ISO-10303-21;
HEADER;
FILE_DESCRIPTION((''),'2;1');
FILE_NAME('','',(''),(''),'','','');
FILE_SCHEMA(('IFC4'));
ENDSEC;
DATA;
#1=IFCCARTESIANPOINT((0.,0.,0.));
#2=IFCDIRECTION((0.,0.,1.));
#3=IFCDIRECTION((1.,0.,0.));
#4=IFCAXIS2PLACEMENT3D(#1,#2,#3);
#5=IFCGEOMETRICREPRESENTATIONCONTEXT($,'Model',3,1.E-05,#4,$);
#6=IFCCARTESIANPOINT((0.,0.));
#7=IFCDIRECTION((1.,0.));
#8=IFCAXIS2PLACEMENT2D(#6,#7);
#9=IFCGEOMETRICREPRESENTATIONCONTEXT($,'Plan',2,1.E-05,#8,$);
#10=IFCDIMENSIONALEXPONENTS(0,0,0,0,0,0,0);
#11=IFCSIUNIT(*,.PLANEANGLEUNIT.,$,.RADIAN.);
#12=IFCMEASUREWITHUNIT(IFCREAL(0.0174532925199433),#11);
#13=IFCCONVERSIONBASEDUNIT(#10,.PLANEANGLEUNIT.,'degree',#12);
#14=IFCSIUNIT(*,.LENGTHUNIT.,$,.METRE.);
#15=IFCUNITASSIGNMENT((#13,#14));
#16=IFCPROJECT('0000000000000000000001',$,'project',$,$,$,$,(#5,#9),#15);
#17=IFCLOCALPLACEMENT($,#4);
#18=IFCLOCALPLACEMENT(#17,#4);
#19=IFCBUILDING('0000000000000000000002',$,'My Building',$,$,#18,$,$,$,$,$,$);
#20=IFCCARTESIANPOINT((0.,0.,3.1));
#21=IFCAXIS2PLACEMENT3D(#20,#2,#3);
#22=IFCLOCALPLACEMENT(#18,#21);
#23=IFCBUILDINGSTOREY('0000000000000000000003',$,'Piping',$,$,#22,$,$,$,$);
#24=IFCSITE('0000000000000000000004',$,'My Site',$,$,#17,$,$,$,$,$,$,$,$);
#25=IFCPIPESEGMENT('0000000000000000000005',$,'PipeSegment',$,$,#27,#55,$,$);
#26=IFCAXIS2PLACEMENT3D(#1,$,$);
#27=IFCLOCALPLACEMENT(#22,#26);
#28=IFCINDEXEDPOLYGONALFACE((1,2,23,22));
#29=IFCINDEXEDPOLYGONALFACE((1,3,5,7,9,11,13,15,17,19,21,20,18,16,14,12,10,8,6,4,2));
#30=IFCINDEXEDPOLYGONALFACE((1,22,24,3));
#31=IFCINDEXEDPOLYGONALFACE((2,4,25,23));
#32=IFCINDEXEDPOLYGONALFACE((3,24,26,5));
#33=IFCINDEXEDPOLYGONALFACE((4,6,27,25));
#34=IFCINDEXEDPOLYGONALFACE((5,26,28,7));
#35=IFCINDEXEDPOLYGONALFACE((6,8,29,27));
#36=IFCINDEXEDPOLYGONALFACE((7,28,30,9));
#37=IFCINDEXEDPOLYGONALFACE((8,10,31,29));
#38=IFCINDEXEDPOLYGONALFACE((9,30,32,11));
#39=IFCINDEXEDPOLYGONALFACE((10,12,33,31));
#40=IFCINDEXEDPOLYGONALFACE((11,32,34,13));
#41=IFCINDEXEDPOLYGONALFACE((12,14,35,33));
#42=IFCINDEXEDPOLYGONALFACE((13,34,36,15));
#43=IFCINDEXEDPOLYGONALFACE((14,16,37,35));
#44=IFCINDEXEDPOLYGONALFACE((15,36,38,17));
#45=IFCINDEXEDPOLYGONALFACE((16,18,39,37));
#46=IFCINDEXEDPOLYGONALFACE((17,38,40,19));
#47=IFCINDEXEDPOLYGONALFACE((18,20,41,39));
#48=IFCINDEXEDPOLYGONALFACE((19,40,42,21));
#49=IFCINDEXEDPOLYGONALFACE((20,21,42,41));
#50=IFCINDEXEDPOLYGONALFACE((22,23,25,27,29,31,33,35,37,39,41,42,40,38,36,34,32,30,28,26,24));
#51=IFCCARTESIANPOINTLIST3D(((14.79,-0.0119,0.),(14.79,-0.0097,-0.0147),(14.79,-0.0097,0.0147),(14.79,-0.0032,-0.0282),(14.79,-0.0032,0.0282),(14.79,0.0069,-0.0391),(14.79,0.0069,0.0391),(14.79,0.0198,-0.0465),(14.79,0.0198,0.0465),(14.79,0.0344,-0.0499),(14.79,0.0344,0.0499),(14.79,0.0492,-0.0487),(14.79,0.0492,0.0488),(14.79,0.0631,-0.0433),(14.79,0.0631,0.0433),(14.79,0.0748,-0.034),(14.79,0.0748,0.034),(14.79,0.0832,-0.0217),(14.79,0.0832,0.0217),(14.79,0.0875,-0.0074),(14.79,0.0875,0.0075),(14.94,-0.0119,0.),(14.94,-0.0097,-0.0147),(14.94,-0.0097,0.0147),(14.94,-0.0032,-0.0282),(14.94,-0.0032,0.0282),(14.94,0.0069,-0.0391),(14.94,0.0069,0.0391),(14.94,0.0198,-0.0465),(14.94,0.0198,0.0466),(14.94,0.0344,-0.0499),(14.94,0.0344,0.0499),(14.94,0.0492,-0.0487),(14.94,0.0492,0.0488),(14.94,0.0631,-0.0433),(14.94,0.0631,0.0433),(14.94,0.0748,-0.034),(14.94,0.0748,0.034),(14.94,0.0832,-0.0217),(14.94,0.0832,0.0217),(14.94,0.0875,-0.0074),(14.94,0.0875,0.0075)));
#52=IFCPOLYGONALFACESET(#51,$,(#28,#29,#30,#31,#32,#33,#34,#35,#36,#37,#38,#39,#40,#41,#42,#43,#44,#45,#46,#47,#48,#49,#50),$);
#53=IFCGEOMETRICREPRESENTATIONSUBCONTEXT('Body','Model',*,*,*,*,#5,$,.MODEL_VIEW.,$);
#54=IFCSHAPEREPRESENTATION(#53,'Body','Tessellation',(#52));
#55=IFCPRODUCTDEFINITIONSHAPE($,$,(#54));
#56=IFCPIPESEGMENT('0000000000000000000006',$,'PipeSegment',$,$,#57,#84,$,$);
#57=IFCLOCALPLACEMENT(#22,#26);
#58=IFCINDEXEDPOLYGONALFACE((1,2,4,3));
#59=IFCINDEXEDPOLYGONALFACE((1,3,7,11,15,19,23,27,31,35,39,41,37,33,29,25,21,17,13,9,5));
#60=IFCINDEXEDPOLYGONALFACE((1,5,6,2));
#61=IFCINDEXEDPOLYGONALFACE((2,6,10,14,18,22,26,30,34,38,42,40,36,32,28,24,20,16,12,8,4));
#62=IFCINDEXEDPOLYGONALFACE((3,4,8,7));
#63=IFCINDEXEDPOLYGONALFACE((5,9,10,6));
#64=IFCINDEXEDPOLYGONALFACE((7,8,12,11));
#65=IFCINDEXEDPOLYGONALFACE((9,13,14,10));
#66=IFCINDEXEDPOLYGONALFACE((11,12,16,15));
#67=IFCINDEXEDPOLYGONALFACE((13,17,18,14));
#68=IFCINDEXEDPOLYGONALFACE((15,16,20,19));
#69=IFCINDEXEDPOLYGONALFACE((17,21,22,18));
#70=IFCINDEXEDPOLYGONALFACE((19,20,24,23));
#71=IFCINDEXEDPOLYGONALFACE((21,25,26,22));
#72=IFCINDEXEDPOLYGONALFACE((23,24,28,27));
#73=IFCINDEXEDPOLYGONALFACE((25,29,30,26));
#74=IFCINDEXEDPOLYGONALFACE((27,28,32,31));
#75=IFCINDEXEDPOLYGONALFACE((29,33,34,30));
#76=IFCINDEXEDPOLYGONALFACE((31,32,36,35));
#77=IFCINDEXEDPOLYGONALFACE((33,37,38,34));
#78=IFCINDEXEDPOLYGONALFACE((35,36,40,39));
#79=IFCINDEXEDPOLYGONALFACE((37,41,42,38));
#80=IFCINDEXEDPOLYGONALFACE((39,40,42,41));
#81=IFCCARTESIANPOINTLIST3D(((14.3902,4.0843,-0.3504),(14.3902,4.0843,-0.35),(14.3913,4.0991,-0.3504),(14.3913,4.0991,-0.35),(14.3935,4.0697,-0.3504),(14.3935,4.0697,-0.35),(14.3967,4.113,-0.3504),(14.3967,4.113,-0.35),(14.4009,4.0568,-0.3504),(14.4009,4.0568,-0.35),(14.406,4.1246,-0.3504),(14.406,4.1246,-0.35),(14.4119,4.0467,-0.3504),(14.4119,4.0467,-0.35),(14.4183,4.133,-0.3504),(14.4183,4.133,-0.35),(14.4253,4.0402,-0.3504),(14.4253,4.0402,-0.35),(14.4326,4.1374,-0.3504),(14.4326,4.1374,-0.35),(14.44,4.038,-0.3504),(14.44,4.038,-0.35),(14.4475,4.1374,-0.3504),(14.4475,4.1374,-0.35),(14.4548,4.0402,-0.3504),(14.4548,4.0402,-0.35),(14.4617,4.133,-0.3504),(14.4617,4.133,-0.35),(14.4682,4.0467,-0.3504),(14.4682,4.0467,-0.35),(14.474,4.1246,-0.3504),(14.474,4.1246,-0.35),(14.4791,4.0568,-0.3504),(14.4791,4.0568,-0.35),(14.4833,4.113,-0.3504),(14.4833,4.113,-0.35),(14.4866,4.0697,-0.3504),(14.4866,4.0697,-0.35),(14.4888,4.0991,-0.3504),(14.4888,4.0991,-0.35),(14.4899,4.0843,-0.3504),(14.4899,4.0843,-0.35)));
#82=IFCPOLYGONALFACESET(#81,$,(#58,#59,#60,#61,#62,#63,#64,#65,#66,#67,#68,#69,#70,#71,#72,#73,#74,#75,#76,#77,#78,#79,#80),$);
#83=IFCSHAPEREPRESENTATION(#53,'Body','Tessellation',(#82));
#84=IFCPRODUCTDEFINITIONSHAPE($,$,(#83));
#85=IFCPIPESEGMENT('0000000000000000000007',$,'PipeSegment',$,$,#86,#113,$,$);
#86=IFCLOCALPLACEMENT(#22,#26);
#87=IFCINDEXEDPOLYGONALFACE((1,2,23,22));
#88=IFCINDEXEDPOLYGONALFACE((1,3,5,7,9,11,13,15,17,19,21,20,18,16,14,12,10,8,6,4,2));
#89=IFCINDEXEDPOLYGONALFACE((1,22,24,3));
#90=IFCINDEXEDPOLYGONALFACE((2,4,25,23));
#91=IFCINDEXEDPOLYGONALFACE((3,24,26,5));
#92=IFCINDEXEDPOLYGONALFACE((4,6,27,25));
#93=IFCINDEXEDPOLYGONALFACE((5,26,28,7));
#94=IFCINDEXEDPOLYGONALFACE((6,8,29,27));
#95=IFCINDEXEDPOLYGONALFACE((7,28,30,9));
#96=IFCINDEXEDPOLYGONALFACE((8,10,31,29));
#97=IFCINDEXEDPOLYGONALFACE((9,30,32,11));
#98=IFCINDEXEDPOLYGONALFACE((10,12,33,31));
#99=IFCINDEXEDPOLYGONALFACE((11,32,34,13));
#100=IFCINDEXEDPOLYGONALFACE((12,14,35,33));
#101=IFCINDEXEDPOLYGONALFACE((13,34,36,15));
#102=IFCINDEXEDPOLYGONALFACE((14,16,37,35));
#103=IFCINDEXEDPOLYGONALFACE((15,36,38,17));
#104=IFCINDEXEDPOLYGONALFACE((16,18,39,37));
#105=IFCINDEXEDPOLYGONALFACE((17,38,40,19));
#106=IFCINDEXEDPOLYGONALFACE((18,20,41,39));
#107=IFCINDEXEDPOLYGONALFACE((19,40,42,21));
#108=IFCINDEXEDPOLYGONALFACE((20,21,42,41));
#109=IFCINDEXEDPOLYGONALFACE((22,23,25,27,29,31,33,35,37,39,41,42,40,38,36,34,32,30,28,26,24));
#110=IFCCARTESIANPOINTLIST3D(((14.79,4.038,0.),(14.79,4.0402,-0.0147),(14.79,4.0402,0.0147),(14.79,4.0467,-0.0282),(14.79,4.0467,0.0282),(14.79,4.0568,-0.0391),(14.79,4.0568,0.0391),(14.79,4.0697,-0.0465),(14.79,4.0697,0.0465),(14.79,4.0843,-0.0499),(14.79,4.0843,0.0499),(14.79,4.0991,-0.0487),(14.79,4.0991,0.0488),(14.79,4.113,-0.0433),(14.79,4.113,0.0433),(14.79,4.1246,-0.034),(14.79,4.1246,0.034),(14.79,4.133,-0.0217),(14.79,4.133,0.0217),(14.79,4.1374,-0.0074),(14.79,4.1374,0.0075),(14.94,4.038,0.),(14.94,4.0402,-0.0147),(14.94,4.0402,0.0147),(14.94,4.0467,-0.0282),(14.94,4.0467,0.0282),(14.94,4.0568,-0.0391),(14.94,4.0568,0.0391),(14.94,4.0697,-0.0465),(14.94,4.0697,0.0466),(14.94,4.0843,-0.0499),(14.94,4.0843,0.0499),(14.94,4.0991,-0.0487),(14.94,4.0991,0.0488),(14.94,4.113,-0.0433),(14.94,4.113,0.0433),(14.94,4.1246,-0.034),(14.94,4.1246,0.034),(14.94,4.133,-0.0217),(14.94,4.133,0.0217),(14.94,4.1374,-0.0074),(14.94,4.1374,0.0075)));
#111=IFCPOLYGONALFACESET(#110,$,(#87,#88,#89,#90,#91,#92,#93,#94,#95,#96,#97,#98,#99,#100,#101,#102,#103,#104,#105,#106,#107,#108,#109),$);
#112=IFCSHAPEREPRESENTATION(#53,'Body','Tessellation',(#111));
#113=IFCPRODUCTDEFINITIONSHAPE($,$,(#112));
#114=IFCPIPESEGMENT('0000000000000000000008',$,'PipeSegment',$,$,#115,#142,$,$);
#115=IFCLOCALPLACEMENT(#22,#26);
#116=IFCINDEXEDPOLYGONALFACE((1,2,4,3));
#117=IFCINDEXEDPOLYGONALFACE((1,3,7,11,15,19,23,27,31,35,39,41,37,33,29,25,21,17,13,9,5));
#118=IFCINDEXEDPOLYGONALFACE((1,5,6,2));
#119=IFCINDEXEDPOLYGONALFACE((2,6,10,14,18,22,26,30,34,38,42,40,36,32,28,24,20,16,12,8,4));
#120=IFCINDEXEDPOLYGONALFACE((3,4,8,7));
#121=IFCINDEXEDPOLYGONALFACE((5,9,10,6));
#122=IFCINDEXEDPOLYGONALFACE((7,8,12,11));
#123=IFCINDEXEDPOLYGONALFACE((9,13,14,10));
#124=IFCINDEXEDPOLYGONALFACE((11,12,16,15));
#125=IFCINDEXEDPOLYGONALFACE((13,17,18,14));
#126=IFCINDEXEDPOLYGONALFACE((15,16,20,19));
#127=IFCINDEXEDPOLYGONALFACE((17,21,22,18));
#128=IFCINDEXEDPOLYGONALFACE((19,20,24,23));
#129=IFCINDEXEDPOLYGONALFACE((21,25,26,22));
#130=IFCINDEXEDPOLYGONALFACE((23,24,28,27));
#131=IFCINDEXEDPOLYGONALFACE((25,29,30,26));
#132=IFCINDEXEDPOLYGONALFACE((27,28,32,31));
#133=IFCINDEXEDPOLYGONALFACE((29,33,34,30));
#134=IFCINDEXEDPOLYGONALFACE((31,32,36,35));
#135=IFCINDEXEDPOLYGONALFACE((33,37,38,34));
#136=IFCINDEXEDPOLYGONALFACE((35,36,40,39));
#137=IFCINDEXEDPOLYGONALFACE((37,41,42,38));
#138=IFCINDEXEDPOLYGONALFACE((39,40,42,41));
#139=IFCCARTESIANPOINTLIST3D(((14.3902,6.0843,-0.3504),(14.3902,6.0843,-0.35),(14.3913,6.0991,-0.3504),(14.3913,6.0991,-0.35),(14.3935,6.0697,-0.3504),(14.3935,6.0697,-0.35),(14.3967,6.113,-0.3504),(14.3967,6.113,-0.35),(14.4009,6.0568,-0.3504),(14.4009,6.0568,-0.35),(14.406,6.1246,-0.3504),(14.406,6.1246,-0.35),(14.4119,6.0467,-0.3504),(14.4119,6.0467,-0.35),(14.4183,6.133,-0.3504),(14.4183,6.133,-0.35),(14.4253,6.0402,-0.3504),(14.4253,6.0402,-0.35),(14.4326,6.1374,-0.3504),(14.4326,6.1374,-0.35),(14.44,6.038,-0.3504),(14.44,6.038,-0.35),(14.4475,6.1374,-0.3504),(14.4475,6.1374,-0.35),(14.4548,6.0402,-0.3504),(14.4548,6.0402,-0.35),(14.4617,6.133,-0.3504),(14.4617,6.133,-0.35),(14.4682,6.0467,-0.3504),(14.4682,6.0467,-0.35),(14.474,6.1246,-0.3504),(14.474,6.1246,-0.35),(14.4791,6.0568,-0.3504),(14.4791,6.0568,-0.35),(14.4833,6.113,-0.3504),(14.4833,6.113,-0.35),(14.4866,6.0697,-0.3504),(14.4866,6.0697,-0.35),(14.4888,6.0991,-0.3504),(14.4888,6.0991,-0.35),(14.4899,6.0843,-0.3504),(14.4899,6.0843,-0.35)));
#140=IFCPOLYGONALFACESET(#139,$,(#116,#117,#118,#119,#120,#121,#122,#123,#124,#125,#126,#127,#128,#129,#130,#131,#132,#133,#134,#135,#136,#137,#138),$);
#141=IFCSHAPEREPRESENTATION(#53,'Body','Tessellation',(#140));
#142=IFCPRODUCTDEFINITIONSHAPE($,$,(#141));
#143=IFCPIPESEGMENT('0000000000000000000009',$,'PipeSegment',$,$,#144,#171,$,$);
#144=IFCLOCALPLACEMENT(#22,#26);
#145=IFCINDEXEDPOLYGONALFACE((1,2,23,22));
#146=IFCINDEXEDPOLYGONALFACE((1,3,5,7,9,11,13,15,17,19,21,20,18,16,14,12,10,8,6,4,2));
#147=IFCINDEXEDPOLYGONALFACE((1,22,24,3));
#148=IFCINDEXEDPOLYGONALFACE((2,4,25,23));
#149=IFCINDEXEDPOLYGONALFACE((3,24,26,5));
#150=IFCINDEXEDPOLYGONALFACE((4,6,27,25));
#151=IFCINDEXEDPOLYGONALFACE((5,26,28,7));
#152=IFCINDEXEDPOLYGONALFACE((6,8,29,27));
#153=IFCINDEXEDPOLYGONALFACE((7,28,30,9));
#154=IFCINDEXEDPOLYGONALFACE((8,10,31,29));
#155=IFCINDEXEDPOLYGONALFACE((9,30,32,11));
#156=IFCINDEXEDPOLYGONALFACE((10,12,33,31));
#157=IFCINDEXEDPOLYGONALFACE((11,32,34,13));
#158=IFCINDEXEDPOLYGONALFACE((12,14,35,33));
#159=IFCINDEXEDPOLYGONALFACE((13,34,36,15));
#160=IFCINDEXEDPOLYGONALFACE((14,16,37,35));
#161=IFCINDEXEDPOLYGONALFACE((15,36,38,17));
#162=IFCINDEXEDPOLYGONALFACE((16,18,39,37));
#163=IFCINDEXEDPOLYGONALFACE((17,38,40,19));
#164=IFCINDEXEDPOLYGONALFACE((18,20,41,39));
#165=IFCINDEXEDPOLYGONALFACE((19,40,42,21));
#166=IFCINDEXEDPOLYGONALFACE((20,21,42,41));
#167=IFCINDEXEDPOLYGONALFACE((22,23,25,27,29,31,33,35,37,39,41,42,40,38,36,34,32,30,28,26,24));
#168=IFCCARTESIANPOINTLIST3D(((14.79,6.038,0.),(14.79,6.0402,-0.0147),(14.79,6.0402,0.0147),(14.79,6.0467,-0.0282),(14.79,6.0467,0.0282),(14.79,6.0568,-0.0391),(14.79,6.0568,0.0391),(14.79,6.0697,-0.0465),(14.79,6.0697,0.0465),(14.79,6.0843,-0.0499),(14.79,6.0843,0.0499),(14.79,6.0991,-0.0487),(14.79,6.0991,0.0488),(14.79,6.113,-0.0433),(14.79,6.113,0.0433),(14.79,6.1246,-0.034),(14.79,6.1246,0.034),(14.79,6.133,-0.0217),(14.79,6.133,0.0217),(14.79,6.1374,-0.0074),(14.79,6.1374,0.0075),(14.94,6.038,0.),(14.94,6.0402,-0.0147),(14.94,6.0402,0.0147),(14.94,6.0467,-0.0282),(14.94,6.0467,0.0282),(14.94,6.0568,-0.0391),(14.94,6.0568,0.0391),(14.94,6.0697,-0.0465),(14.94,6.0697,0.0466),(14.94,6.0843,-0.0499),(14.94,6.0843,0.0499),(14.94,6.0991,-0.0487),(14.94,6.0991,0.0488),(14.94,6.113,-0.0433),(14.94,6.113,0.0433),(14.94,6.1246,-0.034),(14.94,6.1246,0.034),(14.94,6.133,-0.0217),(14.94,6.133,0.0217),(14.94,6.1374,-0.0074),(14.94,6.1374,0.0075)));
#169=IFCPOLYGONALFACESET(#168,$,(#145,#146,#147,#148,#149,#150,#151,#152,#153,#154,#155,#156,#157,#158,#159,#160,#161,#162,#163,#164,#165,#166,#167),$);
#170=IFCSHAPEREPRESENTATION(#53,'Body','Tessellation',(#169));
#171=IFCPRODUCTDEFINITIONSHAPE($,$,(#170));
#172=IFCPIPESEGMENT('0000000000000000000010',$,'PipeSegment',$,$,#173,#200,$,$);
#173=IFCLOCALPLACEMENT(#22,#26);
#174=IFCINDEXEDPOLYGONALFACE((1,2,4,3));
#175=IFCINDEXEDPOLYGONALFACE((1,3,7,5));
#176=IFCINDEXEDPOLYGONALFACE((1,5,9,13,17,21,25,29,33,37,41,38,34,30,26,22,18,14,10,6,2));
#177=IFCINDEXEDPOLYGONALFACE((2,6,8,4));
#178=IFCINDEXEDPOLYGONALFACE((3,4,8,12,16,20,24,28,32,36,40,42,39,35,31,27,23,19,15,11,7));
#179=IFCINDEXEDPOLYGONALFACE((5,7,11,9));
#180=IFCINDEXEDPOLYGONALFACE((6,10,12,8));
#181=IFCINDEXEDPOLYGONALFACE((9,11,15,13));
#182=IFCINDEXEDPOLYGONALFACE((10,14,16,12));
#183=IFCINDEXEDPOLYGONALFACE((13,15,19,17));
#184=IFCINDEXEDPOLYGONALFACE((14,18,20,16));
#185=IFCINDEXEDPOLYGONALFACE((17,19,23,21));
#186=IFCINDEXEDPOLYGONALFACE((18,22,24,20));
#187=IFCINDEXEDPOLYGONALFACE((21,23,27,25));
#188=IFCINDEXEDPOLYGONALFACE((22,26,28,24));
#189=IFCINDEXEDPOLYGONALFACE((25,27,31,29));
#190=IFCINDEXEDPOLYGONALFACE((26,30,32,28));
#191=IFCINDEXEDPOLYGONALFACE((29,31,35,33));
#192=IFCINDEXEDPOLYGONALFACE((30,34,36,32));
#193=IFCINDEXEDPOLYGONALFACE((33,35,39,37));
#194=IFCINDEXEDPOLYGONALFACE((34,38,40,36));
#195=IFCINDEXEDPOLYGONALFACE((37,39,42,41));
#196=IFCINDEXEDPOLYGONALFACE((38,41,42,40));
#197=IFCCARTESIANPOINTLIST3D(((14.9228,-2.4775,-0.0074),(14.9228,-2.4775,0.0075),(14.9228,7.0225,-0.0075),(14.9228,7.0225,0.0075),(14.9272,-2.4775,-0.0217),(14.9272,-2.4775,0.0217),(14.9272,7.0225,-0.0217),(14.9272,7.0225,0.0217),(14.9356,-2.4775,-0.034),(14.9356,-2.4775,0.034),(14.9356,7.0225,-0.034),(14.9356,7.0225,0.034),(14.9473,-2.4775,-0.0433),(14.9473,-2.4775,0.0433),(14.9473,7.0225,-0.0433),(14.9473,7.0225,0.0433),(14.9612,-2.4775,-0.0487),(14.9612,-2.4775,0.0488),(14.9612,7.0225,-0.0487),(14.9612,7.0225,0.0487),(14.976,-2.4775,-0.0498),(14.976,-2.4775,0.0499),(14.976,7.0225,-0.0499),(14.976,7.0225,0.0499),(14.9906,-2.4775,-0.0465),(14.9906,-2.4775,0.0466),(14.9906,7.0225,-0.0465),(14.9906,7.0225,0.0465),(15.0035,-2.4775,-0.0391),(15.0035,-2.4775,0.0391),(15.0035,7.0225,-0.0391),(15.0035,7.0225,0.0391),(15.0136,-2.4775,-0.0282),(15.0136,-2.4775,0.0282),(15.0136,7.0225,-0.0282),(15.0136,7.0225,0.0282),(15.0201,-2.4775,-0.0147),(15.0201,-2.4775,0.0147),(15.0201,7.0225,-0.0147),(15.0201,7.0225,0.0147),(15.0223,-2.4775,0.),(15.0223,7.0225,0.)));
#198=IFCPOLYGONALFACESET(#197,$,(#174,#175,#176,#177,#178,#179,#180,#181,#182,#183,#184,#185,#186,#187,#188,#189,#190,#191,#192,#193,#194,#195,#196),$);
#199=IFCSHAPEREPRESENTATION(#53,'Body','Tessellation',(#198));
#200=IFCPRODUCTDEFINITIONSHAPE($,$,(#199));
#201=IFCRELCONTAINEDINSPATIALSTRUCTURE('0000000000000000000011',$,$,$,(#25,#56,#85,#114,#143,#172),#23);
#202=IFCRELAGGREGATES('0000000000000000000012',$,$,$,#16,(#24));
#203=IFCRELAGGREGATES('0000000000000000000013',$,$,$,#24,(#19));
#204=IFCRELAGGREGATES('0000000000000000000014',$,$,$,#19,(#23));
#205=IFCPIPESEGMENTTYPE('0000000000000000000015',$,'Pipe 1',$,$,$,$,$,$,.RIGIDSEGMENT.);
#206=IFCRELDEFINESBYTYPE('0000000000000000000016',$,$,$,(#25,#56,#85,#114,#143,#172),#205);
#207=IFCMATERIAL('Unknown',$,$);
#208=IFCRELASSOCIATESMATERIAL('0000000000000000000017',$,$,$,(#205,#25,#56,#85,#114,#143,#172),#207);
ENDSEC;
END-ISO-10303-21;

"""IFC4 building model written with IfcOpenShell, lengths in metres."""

from ifc_helpers import new_model, entity, si_unit, converted_unit, frame, origin_with_axes, origin_2d_with_axis, place, context, subcontext, project, spatial, circle, extrude, material, material_profile, profile_set, profile_usage, type_object, element, save


model = new_model("IFC4")

# Units and contexts
model_context = context("Model", 3, precision=1e-05, world=origin_with_axes())
plan_context = context("Plan", 2, precision=1e-05, world=origin_2d_with_axis())
body_context = subcontext(model_context, "Body", "Model", "MODEL_VIEW")
ifc_project = project(units=[converted_unit("PLANEANGLEUNIT", "degree", entity("IfcReal", 0.0174532925199433), si_unit("PLANEANGLEUNIT", "RADIAN"), dimensions=[0, 0, 0, 0, 0, 0, 0]), si_unit("LENGTHUNIT", "METRE")], contexts=[model_context, plan_context])

# Site, building, storey
site_placement = place(None, origin_with_axes())
site = spatial("IfcSite", under=ifc_project, at=site_placement, Name="My Site")
building_placement = place(site_placement, origin_with_axes())
building = spatial("IfcBuilding", under=site, at=building_placement, Name="My Building")
storey_placement = place(building_placement, frame((0.0, 0.0, 3.1), z_axis=(0.0, 0.0, 1.0), x_axis=(1.0, 0.0, 0.0)))
storey = spatial("IfcBuildingStorey", under=building, at=storey_placement, Name="Piping")

# Pipe segments
ifc_material = material(Name="Unknown")
ifc_material_profile = material_profile(ifc_material, circle(Radius=0.05))
ifc_profile_set = profile_set([ifc_material_profile])
pipe_segment_type = type_object("IfcPipeSegmentType", Name="Pipe 1", PredefinedType="RIGIDSEGMENT", material=ifc_profile_set)
ifc_profile_usage_1 = profile_usage(ifc_profile_set, cardinal=5)
pipe_segment_1_placement = place(storey_placement, frame((14.94, 0.0381, 0.0), z_axis=(-1.0, 0.0, -0.000022), x_axis=(0.0, -1.0, 0.0)))
element("IfcPipeSegment", 1, at=pipe_segment_1_placement, inside=storey, type_object=pipe_segment_type, material=ifc_profile_usage_1, Name="PipeSegment", context=body_context, shape_type="SweptSolid", body=[
    extrude(circle(Radius=0.05), origin_with_axes(), (0.0, 0.0, 1.0), 0.15),
])
ifc_profile_usage_2 = profile_usage(ifc_profile_set, cardinal=5)
pipe_segment_2_placement = place(storey_placement, frame((14.44, 4.088, -0.35), z_axis=(0.0, 0.0, -1.0), x_axis=(0.0, -1.0, 0.0)))
element("IfcPipeSegment", 2, at=pipe_segment_2_placement, inside=storey, type_object=pipe_segment_type, material=ifc_profile_usage_2, Name="PipeSegment", context=body_context, shape_type="SweptSolid", body=[
    extrude(circle(Radius=0.05), origin_with_axes(), (0.0, 0.0, 1.0), 0.0004),
])
ifc_profile_usage_3 = profile_usage(ifc_profile_set, cardinal=5)
pipe_segment_3_placement = place(storey_placement, frame((14.94, 4.088, 0.0), z_axis=(-1.0, 0.0, -0.000022), x_axis=(0.0, -1.0, 0.0)))
element("IfcPipeSegment", 3, at=pipe_segment_3_placement, inside=storey, type_object=pipe_segment_type, material=ifc_profile_usage_3, Name="PipeSegment", context=body_context, shape_type="SweptSolid", body=[
    extrude(circle(Radius=0.05), origin_with_axes(), (0.0, 0.0, 1.0), 0.15),
])
ifc_profile_usage_4 = profile_usage(ifc_profile_set, cardinal=5)
pipe_segment_4_placement = place(storey_placement, frame((14.44, 6.088, -0.35), z_axis=(0.0, 0.0, -1.0), x_axis=(0.0, -1.0, 0.0)))
element("IfcPipeSegment", 4, at=pipe_segment_4_placement, inside=storey, type_object=pipe_segment_type, material=ifc_profile_usage_4, Name="PipeSegment", context=body_context, shape_type="SweptSolid", body=[
    extrude(circle(Radius=0.05), origin_with_axes(), (0.0, 0.0, 1.0), 0.0004),
])
ifc_profile_usage_5 = profile_usage(ifc_profile_set, cardinal=5)
pipe_segment_5_placement = place(storey_placement, frame((14.94, 6.088, 0.0), z_axis=(-1.0, 0.0, -0.000022), x_axis=(0.0, -1.0, 0.0)))
element("IfcPipeSegment", 5, at=pipe_segment_5_placement, inside=storey, type_object=pipe_segment_type, material=ifc_profile_usage_5, Name="PipeSegment", context=body_context, shape_type="SweptSolid", body=[
    extrude(circle(Radius=0.05), origin_with_axes(), (0.0, 0.0, 1.0), 0.15),
])
ifc_profile_usage_6 = profile_usage(ifc_profile_set, cardinal=5)
pipe_segment_6_placement = place(storey_placement, frame((14.9723, 7.0225, 0.0), z_axis=(0.0, -1.0, 0.000001), x_axis=(1.0, 0.0, 0.0)))
element("IfcPipeSegment", 6, at=pipe_segment_6_placement, inside=storey, type_object=pipe_segment_type, material=ifc_profile_usage_6, Name="PipeSegment", context=body_context, shape_type="SweptSolid", body=[
    extrude(circle(Radius=0.05), origin_with_axes(), (0.0, 0.0, 1.0), 9.5),
])

save(model, "model.ifc")
